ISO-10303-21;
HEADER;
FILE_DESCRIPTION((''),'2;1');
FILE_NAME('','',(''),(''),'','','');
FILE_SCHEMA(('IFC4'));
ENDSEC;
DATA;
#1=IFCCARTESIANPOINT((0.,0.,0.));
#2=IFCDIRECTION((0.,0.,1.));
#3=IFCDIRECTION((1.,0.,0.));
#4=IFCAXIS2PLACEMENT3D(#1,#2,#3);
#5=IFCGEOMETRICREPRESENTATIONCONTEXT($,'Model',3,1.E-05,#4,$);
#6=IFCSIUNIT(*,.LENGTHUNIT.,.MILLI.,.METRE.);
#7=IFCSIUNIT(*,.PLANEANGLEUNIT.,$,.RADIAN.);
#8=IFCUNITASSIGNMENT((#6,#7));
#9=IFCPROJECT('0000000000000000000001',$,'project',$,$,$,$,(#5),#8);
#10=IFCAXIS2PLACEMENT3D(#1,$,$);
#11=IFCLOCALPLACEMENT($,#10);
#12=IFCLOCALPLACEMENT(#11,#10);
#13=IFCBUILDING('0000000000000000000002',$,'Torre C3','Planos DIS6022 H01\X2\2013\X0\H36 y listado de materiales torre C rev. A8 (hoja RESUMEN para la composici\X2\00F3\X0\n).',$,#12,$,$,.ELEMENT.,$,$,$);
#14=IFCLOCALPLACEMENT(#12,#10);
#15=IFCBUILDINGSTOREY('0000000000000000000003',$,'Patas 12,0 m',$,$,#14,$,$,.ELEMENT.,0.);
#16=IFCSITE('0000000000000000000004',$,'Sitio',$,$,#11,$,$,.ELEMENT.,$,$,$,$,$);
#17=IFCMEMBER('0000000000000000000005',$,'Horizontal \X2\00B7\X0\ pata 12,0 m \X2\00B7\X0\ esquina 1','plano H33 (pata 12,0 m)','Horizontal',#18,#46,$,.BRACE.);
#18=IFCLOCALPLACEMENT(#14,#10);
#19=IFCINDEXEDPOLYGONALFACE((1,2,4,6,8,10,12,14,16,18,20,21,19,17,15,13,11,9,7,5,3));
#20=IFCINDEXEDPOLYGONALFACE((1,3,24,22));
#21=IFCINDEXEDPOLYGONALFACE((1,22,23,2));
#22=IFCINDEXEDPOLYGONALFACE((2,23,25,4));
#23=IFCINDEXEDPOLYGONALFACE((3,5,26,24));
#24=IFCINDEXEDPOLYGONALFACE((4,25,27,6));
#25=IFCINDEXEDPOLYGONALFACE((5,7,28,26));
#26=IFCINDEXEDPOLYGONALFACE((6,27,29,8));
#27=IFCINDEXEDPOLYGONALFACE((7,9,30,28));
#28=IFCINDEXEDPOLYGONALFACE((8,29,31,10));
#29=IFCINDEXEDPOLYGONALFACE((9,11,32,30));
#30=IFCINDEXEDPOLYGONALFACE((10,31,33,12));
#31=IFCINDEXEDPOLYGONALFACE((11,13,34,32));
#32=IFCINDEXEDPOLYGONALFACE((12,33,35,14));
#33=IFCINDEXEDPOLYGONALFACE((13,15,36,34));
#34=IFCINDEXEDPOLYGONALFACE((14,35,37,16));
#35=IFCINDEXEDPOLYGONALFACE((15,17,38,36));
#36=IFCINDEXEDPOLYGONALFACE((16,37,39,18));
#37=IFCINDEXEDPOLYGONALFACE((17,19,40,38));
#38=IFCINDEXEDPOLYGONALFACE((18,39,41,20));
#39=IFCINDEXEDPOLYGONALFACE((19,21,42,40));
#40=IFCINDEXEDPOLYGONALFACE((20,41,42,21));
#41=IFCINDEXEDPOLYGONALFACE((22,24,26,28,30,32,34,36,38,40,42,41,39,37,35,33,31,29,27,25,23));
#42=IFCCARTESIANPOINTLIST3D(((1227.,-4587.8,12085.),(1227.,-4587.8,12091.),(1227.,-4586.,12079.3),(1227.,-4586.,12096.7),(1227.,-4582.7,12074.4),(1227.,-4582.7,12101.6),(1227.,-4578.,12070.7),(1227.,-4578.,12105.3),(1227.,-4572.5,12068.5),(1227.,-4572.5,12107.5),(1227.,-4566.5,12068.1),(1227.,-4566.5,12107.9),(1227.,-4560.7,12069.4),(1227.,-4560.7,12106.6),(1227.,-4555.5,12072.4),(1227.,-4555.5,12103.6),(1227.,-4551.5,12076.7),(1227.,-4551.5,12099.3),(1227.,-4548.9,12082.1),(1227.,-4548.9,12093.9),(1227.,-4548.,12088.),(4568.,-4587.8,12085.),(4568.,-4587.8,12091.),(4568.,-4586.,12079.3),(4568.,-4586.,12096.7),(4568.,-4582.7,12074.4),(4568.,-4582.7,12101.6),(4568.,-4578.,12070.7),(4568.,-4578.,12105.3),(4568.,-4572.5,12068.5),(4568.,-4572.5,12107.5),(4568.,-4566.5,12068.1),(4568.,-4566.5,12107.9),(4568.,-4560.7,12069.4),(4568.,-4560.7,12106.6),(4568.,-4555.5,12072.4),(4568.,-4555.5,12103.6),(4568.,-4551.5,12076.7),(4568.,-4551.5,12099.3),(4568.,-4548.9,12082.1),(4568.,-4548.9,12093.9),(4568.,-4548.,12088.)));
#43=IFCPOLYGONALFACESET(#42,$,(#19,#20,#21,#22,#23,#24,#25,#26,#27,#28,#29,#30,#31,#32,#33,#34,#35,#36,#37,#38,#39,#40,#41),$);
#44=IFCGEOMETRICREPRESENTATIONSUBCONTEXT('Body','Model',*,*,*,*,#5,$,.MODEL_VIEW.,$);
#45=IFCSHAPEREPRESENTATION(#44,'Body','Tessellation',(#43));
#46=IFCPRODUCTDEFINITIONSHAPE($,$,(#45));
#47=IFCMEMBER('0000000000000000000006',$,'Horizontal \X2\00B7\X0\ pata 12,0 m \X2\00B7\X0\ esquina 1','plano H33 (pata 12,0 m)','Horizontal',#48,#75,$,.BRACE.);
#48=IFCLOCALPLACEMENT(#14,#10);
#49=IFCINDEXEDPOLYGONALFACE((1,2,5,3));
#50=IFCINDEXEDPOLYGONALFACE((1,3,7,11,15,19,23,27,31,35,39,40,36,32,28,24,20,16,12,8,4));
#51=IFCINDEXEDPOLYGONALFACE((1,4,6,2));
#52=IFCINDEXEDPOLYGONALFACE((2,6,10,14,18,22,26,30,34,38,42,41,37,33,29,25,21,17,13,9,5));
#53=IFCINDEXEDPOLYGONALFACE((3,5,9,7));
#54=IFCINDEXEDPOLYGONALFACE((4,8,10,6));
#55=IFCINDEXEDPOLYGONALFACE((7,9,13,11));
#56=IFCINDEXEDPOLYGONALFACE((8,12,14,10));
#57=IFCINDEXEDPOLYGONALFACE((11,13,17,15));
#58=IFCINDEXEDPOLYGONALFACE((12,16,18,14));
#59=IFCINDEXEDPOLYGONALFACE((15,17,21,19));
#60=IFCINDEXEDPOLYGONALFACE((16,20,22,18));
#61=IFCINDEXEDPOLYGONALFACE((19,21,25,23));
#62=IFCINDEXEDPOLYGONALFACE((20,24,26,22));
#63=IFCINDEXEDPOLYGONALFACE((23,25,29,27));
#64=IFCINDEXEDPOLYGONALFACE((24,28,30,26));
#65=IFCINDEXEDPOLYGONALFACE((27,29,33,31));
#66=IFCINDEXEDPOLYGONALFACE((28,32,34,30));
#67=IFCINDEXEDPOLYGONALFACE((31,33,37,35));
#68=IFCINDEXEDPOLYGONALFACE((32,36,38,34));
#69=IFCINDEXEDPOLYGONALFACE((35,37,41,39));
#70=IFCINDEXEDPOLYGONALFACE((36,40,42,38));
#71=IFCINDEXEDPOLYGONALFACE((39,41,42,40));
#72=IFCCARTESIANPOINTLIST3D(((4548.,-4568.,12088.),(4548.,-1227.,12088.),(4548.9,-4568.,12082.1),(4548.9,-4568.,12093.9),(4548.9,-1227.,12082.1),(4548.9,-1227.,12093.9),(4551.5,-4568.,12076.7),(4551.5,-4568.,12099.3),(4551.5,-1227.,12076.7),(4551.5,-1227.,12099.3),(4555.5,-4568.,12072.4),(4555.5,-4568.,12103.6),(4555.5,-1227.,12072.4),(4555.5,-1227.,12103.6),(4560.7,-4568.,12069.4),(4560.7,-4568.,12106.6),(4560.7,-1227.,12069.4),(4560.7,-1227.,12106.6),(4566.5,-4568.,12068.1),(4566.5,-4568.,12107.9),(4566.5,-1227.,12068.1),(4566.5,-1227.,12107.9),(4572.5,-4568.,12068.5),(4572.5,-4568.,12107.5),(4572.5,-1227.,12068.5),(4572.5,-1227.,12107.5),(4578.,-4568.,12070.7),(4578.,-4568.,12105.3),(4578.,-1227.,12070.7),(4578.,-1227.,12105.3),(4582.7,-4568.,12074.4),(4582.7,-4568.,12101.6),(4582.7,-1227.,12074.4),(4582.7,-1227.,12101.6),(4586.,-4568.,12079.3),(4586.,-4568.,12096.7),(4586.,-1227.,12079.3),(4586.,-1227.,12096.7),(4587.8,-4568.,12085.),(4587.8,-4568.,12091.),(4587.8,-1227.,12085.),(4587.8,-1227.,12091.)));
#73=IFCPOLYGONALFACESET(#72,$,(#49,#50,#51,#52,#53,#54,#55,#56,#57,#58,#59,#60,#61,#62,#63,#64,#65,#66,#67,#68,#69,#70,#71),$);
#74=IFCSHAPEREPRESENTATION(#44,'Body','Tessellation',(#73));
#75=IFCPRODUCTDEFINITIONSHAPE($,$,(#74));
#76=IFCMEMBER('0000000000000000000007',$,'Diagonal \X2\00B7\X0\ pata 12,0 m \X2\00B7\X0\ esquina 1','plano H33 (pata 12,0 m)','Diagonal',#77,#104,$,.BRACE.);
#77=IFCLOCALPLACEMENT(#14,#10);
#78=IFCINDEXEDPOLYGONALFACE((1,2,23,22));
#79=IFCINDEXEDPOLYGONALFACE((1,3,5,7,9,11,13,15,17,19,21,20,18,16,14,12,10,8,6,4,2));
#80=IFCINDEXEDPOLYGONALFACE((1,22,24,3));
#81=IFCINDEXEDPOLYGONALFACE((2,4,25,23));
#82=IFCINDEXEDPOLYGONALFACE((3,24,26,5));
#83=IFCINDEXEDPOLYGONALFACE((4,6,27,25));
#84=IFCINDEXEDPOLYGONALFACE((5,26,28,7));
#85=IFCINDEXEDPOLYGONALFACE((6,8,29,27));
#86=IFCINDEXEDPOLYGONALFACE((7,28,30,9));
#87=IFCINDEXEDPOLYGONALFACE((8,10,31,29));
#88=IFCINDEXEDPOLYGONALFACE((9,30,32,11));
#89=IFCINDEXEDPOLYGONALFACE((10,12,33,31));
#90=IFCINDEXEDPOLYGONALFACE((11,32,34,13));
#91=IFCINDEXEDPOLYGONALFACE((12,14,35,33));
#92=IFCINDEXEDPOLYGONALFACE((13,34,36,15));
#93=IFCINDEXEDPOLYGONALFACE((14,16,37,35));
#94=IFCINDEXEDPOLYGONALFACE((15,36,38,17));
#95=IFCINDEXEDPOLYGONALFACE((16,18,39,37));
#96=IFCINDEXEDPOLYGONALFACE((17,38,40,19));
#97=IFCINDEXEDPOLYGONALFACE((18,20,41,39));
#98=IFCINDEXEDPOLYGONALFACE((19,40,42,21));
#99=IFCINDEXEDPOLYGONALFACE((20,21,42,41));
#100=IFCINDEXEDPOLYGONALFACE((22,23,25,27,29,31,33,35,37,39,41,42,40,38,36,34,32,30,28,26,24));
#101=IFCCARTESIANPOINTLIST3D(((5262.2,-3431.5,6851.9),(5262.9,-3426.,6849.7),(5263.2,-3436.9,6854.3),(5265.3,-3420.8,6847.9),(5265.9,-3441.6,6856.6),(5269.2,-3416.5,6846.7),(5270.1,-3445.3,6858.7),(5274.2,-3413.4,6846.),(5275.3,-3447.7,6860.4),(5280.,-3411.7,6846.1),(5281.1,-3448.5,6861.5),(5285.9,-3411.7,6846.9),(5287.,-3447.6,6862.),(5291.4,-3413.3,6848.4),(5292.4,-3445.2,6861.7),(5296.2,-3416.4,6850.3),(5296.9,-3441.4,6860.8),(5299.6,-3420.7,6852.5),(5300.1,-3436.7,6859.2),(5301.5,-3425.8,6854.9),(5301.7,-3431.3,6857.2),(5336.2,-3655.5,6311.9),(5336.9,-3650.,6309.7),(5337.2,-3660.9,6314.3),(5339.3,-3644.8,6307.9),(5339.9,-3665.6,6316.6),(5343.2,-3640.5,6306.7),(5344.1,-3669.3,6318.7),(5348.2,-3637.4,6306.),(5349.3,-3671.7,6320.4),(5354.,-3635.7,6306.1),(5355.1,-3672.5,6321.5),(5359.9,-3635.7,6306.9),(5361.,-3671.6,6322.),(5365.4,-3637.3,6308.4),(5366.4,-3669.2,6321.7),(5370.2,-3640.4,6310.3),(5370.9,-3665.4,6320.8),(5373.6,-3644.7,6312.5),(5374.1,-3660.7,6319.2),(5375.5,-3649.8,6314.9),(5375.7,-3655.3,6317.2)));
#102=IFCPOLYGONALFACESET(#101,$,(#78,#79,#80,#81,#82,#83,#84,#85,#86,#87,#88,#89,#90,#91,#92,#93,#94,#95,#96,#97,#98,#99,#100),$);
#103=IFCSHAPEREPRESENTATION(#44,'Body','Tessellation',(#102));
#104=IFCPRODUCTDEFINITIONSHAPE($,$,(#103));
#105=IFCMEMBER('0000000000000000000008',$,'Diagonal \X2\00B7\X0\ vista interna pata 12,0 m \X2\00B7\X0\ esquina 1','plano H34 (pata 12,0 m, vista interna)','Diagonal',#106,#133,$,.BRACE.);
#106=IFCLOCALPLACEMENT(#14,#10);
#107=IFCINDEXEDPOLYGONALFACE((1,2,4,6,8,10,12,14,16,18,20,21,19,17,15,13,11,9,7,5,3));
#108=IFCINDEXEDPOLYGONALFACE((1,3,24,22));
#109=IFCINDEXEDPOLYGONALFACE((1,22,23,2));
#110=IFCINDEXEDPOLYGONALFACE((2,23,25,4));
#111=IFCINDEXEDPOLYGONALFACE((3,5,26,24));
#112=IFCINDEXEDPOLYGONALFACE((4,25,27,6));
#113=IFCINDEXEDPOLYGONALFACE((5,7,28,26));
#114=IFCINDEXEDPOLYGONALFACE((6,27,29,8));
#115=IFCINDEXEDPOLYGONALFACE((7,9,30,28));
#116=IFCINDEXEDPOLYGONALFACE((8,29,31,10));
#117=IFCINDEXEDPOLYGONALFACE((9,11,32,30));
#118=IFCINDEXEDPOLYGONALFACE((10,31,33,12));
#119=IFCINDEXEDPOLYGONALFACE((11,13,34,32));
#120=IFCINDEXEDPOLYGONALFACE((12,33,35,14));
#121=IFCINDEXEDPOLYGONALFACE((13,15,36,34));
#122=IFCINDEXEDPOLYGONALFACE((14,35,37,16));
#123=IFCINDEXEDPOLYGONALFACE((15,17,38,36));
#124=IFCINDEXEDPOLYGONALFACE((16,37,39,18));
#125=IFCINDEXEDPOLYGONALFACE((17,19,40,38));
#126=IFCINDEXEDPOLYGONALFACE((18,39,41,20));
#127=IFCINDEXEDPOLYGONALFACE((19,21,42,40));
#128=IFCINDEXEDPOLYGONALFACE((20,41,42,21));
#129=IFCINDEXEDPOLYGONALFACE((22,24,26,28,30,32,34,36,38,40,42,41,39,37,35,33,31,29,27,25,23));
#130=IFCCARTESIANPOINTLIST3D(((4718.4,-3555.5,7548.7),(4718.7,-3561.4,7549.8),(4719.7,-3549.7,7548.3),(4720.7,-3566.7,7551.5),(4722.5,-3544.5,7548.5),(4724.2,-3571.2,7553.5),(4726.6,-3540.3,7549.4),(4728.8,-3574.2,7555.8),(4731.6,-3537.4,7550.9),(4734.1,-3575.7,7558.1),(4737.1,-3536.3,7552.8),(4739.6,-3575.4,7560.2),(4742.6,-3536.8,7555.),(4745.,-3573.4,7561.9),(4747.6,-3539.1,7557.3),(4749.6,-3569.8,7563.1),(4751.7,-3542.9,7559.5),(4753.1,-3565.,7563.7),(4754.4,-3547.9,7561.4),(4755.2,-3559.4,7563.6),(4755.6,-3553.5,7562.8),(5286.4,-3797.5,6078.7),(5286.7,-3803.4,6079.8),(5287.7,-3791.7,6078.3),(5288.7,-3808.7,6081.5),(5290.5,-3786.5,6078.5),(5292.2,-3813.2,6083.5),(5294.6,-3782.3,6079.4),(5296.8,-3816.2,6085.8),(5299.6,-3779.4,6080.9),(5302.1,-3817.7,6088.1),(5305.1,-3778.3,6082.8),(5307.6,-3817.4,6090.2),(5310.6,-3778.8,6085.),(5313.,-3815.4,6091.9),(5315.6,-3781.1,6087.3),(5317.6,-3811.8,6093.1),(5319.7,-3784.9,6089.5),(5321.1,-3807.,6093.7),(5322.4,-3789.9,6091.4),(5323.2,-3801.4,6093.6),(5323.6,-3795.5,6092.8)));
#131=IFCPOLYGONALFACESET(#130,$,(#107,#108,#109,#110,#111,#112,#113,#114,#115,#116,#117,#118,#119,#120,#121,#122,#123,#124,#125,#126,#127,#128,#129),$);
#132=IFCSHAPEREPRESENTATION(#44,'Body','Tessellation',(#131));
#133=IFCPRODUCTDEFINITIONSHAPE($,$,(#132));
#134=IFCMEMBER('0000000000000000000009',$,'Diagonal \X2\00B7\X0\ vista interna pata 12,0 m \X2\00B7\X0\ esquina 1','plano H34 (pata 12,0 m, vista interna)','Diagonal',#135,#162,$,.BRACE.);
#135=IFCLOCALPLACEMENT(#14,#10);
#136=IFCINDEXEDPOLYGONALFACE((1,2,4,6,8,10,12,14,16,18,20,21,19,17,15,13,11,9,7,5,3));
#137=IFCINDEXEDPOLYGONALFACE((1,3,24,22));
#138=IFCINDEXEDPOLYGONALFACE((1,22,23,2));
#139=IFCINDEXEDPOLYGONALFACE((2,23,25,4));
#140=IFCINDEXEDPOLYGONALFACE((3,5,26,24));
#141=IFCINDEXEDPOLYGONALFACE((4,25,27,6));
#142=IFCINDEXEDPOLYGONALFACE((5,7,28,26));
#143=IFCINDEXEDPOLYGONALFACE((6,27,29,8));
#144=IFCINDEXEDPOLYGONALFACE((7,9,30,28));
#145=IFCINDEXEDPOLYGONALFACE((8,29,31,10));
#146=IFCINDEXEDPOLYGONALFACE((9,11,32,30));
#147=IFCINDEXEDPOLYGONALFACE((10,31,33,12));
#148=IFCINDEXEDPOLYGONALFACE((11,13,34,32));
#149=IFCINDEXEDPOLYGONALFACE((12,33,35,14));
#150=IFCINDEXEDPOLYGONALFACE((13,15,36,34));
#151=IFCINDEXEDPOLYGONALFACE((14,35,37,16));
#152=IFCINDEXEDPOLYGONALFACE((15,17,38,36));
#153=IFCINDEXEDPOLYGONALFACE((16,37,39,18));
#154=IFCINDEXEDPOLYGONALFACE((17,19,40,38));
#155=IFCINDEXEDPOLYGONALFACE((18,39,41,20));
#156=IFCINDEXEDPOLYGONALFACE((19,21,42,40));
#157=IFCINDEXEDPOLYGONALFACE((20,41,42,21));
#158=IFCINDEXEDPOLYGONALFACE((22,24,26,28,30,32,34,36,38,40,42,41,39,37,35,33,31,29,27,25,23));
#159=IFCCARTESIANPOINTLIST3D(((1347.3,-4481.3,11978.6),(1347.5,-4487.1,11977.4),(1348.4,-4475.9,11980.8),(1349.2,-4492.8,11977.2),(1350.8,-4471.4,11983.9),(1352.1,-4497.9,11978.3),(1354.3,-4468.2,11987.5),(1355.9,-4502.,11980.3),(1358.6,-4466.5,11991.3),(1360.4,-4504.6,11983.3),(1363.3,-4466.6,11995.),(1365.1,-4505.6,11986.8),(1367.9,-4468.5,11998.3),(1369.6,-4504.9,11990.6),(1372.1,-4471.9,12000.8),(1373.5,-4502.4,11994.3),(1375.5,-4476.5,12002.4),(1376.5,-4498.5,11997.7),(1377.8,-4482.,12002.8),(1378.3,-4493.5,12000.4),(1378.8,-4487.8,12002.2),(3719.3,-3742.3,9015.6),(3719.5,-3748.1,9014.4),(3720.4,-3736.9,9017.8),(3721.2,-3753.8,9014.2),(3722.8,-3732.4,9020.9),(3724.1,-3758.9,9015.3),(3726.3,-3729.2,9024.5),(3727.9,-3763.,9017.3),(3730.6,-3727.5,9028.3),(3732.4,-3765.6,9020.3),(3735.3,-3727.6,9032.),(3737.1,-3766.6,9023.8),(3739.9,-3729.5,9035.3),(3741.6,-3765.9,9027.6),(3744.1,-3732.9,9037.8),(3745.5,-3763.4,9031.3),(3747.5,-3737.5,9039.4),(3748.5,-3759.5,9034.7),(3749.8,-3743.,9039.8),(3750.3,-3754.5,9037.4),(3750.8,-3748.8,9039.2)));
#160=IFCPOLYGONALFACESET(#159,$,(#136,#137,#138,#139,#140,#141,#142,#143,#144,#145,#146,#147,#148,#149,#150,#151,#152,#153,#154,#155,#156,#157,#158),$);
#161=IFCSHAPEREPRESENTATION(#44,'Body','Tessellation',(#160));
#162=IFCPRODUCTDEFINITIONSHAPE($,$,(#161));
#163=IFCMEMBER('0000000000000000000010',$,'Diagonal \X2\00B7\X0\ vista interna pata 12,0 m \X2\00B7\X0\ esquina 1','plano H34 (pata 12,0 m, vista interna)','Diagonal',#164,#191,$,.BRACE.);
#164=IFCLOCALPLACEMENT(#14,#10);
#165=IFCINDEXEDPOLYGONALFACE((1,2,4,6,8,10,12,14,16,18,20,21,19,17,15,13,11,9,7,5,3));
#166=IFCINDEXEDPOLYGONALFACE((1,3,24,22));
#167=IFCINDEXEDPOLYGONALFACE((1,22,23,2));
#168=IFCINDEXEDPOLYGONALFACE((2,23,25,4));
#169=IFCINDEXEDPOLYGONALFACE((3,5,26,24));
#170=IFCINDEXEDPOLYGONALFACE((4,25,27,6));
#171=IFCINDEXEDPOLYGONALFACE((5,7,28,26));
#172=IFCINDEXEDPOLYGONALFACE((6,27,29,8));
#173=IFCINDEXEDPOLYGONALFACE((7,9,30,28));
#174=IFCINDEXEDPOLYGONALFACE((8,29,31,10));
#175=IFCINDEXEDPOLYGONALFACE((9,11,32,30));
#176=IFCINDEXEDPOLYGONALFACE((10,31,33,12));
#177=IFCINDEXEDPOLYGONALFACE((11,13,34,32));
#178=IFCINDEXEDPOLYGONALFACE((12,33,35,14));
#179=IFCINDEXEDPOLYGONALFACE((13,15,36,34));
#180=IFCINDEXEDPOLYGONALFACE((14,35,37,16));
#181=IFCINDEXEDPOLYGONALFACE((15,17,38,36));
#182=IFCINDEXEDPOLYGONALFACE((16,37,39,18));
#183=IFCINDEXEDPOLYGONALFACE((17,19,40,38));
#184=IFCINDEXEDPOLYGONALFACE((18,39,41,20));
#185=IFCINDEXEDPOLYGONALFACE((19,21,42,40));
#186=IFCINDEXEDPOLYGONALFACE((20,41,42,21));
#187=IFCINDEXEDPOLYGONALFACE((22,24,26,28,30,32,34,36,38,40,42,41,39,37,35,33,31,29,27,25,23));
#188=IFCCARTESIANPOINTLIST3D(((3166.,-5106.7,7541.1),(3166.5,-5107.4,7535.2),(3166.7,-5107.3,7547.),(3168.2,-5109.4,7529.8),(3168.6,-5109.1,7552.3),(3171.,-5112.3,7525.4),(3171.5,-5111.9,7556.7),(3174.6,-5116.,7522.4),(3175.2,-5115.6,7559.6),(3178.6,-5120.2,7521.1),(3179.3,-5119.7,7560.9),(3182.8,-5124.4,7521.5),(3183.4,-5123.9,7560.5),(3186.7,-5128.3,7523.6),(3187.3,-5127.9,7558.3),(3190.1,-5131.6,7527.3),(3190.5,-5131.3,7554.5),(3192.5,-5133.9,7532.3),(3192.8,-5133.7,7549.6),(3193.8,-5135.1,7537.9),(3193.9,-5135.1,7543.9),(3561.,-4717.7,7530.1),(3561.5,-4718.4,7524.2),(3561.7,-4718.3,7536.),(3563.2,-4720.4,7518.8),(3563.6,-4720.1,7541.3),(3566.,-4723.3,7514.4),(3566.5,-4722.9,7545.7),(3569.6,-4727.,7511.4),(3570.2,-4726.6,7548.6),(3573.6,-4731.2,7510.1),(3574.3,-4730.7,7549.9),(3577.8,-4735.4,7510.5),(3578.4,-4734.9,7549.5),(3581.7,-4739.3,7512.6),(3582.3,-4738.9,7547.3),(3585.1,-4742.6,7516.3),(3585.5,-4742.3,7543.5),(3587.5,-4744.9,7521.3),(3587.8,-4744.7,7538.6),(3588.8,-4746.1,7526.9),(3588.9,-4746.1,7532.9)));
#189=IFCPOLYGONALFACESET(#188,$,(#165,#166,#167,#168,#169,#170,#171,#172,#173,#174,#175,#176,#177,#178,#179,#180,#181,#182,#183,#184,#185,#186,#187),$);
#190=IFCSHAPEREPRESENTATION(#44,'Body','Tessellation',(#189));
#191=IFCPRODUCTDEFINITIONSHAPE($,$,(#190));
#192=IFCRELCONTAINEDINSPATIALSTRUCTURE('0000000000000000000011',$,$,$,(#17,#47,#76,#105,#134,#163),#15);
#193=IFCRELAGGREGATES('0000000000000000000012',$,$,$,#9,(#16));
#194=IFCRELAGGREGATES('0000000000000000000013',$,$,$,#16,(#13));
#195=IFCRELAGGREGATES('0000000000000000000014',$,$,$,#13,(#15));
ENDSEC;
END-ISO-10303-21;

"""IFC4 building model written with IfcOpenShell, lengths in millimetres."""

from ifc_helpers import new_model, si_unit, frame, origin, origin_with_axes, place, context, subcontext, project, spatial, circle, extrude, element, save


model = new_model("IFC4")

# Units and contexts
model_context = context("Model", 3, precision=1e-05, world=origin_with_axes())
body_context = subcontext(model_context, "Body", "Model", "MODEL_VIEW")
ifc_project = project(units=[si_unit("LENGTHUNIT", "METRE", prefix="MILLI"), si_unit("PLANEANGLEUNIT", "RADIAN")], contexts=[model_context])

# Site, building, storey
site_placement = place(None, origin())
site = spatial("IfcSite", under=ifc_project, at=site_placement, Name="Sitio", CompositionType="ELEMENT")
building_placement = place(site_placement, origin())
building = spatial("IfcBuilding", under=site, at=building_placement, Name="Torre C3", Description="Planos DIS6022 H01–H36 y listado de materiales torre C rev. A8 (hoja RESUMEN para la composición).", CompositionType="ELEMENT")
storey_placement = place(building_placement, origin())
storey = spatial("IfcBuildingStorey", under=building, at=storey_placement, Name="Patas 12,0 m", CompositionType="ELEMENT", Elevation=0.0)

# Members
for number, where, z_axis, x_axis, name in (
    (1, (4568.0, -4568.0, 12088.0), (-1.0, 0.0, 0.0), (0.0, 1.0, 0.0), "Horizontal · pata 12,0 m · esquina 1"),
    (2, (4568.0, -4568.0, 12088.0), (0.0, 1.0, 0.0), (-1.0, 0.0, 0.0), "Horizontal · pata 12,0 m · esquina 1"),
):
    element("IfcMember", number, at=place(storey_placement, frame(where, z_axis=z_axis, x_axis=x_axis)), inside=storey, Name=name, Description="plano H33 (pata 12,0 m)", ObjectType="Horizontal", PredefinedType="BRACE", context=body_context, shape_type="SweptSolid", body=[
        extrude(circle(Radius=20.0), None, (0.0, 0.0, 1.0), 3341.0),
    ])
member_1_placement = place(storey_placement, frame((5282.0, -3430.0, 6854.0), z_axis=(0.125577, -0.380124, -0.916371), x_axis=(-0.83534, 0.457784, -0.304368)))
element("IfcMember", 3, at=member_1_placement, inside=storey, Name="Diagonal · pata 12,0 m · esquina 1", Description="plano H33 (pata 12,0 m)", ObjectType="Diagonal", PredefinedType="BRACE", context=body_context, shape_type="SweptSolid", body=[
    extrude(circle(Radius=20.0), None, (0.0, 0.0, 1.0), 589.3),
])
member_2_placement = place(storey_placement, frame((4737.0, -3556.0, 7556.0), z_axis=(0.356249, -0.151782, -0.921981), x_axis=(-0.726055, 0.576131, -0.37539)))
element("IfcMember", 4, at=member_2_placement, inside=storey, Name="Diagonal · vista interna pata 12,0 m · esquina 1", Description="plano H34 (pata 12,0 m, vista interna)", ObjectType="Diagonal", PredefinedType="BRACE", context=body_context, shape_type="SweptSolid", body=[
    extrude(circle(Radius=20.0), None, (0.0, 0.0, 1.0), 1594.4),
])
member_3_placement = place(storey_placement, frame((1363.0, -4486.0, 11990.0), z_axis=(0.613433, 0.191116, -0.766274), x_axis=(-0.433646, 0.892431, -0.12457)))
element("IfcMember", 5, at=member_3_placement, inside=storey, Name="Diagonal · vista interna pata 12,0 m · esquina 1", Description="plano H34 (pata 12,0 m, vista interna)", ObjectType="Diagonal", PredefinedType="BRACE", context=body_context, shape_type="SweptSolid", body=[
    extrude(circle(Radius=20.0), None, (0.0, 0.0, 1.0), 3866.8),
])
member_4_placement = place(storey_placement, frame((3180.0, -5121.0, 7541.0), z_axis=(0.712357, 0.701537, -0.019838), x_axis=(-0.70162, 0.712542, 0.003543)))
element("IfcMember", 6, at=member_4_placement, inside=storey, Name="Diagonal · vista interna pata 12,0 m · esquina 1", Description="plano H34 (pata 12,0 m, vista interna)", ObjectType="Diagonal", PredefinedType="BRACE", context=body_context, shape_type="SweptSolid", body=[
    extrude(circle(Radius=20.0), None, (0.0, 0.0, 1.0), 554.5),
])

save(model, "model.ifc")
